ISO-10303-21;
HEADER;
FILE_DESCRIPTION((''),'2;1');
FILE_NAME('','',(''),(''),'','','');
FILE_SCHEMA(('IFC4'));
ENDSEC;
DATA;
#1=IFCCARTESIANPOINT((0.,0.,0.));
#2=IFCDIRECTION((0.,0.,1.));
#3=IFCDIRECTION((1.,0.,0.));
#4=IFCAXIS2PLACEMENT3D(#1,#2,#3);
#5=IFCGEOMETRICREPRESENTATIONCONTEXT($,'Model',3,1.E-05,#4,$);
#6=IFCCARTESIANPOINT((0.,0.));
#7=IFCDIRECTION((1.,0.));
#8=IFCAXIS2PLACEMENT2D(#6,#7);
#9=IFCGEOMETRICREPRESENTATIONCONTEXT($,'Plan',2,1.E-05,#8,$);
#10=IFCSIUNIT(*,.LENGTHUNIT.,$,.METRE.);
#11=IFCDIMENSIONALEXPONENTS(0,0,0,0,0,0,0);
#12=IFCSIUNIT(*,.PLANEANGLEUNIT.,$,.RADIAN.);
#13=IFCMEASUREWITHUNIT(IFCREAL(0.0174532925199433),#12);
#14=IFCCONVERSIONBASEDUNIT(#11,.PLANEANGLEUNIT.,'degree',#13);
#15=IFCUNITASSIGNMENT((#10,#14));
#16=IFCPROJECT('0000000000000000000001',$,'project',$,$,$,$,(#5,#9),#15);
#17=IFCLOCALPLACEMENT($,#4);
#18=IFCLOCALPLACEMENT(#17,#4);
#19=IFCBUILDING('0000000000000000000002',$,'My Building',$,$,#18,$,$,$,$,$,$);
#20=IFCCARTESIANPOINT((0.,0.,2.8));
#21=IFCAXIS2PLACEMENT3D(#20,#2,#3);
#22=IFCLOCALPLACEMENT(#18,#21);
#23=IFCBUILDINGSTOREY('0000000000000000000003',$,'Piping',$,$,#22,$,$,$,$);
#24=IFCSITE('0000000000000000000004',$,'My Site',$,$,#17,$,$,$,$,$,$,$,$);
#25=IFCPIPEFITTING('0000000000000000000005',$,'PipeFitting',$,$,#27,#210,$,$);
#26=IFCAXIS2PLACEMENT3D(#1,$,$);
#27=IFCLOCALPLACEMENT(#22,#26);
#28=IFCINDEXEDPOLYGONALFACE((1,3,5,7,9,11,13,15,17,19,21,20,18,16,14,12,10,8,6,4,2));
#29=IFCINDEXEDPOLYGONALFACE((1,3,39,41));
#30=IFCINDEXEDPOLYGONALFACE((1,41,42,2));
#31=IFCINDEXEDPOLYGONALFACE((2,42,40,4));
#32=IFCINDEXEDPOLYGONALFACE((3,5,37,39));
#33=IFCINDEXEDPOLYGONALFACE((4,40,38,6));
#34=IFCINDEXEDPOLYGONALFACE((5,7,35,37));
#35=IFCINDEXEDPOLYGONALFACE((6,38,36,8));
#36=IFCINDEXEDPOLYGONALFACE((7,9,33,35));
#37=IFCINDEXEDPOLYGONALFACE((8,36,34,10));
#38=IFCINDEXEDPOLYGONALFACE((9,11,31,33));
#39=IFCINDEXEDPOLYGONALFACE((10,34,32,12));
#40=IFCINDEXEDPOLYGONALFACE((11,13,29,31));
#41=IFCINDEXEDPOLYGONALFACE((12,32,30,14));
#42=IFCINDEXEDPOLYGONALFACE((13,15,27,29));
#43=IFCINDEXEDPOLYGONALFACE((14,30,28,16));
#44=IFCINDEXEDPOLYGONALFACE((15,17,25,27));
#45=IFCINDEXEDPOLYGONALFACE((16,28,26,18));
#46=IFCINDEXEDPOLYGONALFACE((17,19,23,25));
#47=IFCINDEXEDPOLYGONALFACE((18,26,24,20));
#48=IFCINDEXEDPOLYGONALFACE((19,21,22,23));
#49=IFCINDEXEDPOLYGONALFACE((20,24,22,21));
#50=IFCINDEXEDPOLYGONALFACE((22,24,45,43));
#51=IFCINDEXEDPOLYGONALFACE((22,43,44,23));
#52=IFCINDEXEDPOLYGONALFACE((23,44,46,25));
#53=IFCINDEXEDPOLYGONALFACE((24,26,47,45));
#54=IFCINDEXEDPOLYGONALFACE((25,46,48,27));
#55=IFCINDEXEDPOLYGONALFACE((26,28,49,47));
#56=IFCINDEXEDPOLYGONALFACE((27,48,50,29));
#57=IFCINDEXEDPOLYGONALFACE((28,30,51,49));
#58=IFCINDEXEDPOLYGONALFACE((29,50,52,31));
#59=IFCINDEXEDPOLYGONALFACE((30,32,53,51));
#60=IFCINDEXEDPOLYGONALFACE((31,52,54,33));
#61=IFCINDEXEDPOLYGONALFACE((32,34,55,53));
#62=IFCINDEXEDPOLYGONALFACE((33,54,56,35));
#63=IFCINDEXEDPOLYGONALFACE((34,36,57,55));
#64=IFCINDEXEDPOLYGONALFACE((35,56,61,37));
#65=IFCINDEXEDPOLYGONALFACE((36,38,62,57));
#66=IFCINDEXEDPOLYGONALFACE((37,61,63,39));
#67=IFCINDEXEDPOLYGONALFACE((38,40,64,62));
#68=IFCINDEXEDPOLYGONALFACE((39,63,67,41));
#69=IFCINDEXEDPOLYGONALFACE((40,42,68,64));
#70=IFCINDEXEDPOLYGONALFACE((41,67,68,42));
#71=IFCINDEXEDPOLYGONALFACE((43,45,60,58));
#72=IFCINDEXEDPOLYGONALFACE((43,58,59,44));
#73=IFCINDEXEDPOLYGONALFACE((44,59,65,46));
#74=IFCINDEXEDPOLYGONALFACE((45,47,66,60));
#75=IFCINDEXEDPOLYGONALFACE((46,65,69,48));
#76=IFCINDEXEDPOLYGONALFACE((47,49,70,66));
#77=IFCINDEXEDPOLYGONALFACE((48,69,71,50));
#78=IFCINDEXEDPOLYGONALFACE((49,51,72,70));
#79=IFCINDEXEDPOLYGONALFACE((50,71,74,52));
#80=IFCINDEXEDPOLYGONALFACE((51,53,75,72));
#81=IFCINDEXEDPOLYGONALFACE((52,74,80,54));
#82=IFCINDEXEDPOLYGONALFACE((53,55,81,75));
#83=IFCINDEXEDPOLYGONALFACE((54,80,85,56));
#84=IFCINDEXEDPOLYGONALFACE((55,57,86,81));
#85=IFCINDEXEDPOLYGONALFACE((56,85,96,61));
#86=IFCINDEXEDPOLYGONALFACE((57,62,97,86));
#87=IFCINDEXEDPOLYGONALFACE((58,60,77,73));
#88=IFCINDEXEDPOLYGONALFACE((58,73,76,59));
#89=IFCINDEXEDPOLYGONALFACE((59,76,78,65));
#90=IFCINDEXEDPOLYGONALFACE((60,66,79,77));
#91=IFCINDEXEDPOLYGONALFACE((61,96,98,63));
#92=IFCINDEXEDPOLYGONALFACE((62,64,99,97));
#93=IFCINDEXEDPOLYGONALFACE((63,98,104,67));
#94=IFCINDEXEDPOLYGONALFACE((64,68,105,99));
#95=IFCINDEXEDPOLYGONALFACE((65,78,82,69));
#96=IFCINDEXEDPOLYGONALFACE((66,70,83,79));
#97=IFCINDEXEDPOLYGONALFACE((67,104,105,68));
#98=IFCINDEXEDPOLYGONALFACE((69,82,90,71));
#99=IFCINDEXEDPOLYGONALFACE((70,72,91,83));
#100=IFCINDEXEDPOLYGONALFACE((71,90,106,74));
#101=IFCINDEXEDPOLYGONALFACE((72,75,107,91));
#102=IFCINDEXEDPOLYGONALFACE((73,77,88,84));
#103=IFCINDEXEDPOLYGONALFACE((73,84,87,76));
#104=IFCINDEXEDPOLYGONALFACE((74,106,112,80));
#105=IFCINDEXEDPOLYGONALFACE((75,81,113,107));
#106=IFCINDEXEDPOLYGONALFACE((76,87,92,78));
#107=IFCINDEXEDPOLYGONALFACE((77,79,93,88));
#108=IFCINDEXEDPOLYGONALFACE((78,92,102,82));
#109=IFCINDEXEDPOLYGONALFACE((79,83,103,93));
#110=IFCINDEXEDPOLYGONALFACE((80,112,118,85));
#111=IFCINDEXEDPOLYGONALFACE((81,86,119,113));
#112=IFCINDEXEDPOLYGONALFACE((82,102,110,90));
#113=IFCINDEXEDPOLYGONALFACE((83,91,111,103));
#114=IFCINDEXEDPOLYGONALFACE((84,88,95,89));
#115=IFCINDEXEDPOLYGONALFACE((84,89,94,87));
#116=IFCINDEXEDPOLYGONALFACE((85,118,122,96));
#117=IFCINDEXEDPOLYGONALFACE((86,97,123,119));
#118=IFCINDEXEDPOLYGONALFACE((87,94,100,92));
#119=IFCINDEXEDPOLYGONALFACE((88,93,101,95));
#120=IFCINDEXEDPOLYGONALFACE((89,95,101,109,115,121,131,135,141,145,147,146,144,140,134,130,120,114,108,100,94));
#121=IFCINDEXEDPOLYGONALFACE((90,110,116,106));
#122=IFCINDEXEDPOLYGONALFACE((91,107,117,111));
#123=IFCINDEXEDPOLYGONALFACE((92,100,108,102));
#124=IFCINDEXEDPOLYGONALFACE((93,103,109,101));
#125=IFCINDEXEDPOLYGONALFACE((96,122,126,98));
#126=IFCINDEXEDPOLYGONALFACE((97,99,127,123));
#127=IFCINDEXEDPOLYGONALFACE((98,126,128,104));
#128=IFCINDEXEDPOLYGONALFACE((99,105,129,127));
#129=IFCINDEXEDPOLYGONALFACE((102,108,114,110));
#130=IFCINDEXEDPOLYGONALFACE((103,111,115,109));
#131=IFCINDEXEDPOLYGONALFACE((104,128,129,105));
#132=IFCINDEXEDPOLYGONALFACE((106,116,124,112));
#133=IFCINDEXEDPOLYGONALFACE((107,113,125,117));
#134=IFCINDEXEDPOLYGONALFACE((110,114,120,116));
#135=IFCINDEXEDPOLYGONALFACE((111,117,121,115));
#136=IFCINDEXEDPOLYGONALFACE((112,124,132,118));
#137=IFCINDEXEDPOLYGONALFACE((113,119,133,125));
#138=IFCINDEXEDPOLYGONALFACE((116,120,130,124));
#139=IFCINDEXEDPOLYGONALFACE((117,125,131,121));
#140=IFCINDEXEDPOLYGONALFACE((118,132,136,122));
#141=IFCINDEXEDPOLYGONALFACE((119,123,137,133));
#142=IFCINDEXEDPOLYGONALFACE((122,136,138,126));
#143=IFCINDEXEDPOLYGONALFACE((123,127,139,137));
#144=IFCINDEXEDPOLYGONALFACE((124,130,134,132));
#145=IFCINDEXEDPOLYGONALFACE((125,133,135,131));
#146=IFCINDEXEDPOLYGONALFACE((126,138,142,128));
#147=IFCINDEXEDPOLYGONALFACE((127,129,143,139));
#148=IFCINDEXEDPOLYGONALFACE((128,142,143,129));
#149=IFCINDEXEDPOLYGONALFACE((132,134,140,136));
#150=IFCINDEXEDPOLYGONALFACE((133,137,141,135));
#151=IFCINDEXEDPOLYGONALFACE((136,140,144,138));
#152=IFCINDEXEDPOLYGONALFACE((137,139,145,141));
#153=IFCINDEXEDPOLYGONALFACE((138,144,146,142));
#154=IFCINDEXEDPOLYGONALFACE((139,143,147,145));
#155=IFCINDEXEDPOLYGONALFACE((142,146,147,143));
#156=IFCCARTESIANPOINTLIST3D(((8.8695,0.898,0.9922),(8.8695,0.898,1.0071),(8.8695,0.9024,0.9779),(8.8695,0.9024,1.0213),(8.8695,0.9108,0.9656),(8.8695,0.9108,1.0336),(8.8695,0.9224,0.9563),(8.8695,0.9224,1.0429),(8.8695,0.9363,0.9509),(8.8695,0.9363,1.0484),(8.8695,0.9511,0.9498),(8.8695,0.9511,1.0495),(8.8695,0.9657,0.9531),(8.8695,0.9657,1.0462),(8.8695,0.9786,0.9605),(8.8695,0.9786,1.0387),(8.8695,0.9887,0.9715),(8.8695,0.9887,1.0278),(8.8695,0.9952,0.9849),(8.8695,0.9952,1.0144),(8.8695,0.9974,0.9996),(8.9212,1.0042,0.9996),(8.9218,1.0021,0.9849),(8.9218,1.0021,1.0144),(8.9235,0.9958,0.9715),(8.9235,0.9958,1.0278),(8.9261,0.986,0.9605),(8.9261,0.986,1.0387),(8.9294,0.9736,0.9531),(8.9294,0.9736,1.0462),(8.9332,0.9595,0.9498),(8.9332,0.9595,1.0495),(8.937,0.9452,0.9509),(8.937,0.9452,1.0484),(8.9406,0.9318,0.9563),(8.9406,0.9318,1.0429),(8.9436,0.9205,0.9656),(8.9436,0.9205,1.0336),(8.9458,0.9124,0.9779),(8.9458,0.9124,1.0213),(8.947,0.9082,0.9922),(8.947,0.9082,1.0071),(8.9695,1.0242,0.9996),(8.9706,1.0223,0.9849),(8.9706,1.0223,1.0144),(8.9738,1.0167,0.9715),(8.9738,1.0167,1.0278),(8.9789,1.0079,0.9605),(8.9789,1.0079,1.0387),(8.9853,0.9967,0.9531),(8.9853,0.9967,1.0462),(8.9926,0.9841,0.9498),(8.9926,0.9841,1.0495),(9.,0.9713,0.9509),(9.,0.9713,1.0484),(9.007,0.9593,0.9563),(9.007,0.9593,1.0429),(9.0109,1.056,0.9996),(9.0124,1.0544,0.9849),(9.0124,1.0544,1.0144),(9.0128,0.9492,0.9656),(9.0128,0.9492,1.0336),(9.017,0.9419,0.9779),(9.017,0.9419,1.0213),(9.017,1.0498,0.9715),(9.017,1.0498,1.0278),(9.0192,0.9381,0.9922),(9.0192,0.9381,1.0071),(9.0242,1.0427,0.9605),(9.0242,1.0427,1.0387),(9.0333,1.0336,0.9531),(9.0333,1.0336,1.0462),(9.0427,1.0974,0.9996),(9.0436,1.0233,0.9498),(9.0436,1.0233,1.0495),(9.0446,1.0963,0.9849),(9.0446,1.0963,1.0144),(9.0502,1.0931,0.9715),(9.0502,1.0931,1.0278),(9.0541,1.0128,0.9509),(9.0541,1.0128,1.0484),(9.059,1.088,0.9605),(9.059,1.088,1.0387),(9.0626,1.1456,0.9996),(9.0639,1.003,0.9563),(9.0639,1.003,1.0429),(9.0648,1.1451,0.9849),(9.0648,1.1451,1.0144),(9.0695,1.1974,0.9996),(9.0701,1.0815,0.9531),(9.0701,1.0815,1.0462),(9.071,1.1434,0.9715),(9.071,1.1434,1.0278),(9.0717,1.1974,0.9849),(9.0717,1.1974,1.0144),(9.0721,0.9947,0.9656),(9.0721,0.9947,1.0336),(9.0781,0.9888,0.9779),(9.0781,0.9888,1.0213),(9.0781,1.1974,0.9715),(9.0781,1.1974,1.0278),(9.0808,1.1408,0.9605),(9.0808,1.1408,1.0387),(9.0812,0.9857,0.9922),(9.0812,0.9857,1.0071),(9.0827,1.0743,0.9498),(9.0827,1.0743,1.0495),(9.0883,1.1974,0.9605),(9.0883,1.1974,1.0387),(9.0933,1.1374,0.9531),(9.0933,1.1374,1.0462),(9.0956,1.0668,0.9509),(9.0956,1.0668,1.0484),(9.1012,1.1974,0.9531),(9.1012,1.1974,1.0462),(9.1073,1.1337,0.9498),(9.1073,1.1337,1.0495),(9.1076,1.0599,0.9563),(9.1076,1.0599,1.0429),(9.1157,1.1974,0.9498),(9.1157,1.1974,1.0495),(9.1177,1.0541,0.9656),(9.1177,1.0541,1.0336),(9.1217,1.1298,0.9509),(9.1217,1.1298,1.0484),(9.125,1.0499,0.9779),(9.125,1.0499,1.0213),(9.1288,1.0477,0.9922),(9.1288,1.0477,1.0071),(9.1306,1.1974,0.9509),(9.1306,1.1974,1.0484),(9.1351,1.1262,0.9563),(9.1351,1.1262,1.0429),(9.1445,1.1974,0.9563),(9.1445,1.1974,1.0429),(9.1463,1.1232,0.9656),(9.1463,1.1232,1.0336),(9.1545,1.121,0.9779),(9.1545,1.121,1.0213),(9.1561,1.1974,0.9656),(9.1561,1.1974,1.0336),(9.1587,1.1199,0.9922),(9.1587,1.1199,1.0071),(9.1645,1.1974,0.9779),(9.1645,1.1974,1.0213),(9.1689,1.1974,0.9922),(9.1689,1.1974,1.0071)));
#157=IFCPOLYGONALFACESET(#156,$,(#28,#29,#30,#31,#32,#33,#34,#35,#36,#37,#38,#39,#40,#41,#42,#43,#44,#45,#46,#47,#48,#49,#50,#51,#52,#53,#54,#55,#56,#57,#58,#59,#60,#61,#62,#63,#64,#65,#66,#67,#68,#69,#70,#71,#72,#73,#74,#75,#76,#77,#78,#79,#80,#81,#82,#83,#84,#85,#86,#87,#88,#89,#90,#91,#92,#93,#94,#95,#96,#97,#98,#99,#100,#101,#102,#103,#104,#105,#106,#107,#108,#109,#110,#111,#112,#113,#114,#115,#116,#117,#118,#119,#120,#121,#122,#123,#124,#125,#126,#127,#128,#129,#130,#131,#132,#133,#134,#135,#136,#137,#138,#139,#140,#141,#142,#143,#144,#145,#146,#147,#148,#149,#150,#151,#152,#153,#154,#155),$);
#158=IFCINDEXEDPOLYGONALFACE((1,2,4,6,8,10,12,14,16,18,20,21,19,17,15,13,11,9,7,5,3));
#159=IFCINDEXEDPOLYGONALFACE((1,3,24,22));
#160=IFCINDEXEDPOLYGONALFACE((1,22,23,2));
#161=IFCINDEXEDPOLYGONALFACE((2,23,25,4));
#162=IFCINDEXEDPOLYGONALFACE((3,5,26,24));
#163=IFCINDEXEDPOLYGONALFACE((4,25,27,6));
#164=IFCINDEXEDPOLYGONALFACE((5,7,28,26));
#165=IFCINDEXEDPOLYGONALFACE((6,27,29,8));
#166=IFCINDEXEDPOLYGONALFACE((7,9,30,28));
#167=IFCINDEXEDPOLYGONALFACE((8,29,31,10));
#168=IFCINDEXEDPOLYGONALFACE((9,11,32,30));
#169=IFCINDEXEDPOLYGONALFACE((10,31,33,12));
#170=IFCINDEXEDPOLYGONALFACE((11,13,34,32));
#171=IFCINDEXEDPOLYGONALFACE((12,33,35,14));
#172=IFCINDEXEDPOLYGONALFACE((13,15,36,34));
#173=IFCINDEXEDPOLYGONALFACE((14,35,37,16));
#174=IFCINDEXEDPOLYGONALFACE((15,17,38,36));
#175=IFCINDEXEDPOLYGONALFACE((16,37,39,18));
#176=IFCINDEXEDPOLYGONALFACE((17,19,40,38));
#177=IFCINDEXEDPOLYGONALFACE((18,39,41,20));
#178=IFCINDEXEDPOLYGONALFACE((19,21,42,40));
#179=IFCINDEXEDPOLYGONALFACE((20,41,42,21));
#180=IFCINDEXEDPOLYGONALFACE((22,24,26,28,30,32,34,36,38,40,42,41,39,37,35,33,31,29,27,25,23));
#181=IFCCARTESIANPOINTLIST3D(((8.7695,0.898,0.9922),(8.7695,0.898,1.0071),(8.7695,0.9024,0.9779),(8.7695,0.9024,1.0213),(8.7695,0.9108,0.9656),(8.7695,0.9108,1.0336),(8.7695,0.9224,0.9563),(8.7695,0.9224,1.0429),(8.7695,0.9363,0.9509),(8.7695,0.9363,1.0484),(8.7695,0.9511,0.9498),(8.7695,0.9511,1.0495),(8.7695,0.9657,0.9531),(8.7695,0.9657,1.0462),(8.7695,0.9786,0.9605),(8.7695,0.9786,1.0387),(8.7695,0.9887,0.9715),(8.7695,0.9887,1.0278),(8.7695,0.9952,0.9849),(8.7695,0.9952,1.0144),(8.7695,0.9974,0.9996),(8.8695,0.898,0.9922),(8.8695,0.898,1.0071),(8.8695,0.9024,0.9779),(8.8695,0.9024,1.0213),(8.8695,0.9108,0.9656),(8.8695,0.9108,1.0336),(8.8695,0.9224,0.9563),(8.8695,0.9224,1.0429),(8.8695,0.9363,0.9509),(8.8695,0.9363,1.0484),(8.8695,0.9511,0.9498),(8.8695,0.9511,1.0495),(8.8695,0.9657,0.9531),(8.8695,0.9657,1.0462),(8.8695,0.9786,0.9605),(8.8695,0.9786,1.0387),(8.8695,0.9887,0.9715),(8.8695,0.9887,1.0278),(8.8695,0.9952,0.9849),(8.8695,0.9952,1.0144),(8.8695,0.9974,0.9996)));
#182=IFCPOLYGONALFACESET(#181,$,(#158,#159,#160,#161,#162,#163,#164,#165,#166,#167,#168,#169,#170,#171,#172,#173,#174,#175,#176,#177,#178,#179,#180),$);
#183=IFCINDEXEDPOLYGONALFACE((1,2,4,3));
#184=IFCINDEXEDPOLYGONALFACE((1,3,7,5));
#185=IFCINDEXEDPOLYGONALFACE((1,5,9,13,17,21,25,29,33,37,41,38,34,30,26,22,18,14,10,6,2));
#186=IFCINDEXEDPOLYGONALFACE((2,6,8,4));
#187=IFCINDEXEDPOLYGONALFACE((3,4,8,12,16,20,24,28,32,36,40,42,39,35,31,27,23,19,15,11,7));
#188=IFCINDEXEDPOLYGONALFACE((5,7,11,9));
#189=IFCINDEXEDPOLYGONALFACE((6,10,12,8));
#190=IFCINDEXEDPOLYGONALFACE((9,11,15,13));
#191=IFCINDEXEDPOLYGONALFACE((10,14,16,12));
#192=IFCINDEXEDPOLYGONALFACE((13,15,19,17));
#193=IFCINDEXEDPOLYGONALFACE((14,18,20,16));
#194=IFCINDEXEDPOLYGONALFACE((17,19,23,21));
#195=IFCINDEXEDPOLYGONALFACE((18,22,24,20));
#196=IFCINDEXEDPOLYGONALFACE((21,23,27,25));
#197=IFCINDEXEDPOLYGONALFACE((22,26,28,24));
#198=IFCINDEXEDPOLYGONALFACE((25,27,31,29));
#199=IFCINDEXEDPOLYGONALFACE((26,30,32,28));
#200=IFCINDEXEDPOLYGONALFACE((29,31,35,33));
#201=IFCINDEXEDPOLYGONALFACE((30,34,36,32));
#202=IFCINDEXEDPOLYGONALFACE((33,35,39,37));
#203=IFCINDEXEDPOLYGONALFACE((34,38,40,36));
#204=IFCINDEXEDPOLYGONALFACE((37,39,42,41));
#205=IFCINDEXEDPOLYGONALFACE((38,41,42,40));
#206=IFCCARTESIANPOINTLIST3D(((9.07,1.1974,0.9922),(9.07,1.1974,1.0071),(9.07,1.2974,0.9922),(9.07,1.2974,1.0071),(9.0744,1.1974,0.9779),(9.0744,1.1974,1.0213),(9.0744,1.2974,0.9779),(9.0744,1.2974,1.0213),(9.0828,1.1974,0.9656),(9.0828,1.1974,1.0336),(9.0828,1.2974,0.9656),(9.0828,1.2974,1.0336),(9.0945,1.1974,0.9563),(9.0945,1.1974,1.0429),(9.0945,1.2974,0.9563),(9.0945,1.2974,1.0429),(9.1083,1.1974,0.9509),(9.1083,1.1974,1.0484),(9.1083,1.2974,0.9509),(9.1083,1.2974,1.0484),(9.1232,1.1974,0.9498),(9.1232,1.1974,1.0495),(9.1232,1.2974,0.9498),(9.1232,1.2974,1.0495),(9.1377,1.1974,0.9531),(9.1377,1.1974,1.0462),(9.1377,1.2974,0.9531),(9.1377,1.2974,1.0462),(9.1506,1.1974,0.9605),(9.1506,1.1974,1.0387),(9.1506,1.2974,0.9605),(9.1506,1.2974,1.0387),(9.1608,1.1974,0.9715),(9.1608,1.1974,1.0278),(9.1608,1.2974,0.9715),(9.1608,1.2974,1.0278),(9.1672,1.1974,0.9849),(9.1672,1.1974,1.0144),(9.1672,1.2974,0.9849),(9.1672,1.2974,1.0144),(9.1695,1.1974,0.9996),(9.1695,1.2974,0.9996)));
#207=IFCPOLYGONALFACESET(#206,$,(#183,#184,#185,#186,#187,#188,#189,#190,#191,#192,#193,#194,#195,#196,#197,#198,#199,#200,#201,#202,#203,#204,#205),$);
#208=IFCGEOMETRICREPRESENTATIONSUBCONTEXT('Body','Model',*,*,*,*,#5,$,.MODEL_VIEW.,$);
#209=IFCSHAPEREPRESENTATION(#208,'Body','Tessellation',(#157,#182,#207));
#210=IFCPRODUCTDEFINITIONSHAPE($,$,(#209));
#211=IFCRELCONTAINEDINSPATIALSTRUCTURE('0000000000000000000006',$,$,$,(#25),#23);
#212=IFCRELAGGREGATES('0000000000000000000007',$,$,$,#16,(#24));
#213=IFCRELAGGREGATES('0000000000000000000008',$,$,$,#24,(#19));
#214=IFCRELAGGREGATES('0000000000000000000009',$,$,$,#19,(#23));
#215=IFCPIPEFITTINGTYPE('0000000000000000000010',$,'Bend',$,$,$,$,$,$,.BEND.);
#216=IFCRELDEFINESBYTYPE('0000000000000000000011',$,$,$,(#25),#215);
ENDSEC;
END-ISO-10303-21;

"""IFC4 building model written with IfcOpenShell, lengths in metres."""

from ifc_helpers import new_model, entity, si_unit, converted_unit, frame, origin_with_axes, origin_2d_with_axis, place, context, subcontext, project, spatial, circle, extrude, source, transform, mapped, type_object, type_shapes, element, save


model = new_model("IFC4")

# Units and contexts
model_context = context("Model", 3, precision=1e-05, world=origin_with_axes())
plan_context = context("Plan", 2, precision=1e-05, world=origin_2d_with_axis())
body_context = subcontext(model_context, "Body", "Model", "MODEL_VIEW")
ifc_project = project(units=[si_unit("LENGTHUNIT", "METRE"), converted_unit("PLANEANGLEUNIT", "degree", entity("IfcReal", 0.0174532925199433), si_unit("PLANEANGLEUNIT", "RADIAN"), dimensions=[0, 0, 0, 0, 0, 0, 0])], contexts=[model_context, plan_context])

# Site, building, storey
site_placement = place(None, origin_with_axes())
site = spatial("IfcSite", under=ifc_project, at=site_placement, Name="My Site")
building_placement = place(site_placement, origin_with_axes())
building = spatial("IfcBuilding", under=site, at=building_placement, Name="My Building")
storey_placement = place(building_placement, frame((0.0, 0.0, 2.8), z_axis=(0.0, 0.0, 1.0), x_axis=(1.0, 0.0, 0.0)))
storey = spatial("IfcBuildingStorey", under=building, at=storey_placement, Name="Piping")

# Pipe fitting
pipe_fitting_type_1 = type_object("IfcPipeFittingType", Name="Bend", PredefinedType="BEND")
shared_shape = source(origin_with_axes(), body_context, "Body", "SolidModel", [
    entity("IfcSweptDiskSolid", entity("IfcIndexedPolyCurve", entity("IfcCartesianPointList3D", [[0.0, 0.0, 0.1], [0.0732, 0.0, 0.2768], [0.25, 0.0, 0.35]]), [entity("IfcArcIndex", [1, 2, 3])]), 0.05),
    extrude(circle(Radius=0.05), origin_with_axes(), (0.0, 0.0, 1.0), 0.1),
    extrude(circle(Radius=0.05), frame((0.25, 0.0, 0.35), z_axis=(1.0, 0.0, 0.0), x_axis=(0.0, 0.0, 1.0)), (0.0, 0.0, 1.0), 0.1),
])
type_shapes(pipe_fitting_type_1, [shared_shape])
for number, where, z_axis, x_axis, name in (
    (1, (8.7695, 0.9474, 0.9996), (1.0, 0.0, 0.0), (0.0, 1.0, 0.0), "PipeFitting"),
):
    element("IfcPipeFitting", number, at=place(storey_placement, frame(where, z_axis=z_axis, x_axis=x_axis)), inside=storey, type_object=pipe_fitting_type_1, Name=name, context=body_context, shape_type="MappedRepresentation", body=[
        mapped(shared_shape, transform((0.0, 0.0, 0.0), x_axis=(1.0, 0.0, 0.0), y_axis=(0.0, 1.0, 0.0), z_axis=(0.0, 0.0, 1.0), scale=1.0)),
    ])

save(model, "model.ifc")
